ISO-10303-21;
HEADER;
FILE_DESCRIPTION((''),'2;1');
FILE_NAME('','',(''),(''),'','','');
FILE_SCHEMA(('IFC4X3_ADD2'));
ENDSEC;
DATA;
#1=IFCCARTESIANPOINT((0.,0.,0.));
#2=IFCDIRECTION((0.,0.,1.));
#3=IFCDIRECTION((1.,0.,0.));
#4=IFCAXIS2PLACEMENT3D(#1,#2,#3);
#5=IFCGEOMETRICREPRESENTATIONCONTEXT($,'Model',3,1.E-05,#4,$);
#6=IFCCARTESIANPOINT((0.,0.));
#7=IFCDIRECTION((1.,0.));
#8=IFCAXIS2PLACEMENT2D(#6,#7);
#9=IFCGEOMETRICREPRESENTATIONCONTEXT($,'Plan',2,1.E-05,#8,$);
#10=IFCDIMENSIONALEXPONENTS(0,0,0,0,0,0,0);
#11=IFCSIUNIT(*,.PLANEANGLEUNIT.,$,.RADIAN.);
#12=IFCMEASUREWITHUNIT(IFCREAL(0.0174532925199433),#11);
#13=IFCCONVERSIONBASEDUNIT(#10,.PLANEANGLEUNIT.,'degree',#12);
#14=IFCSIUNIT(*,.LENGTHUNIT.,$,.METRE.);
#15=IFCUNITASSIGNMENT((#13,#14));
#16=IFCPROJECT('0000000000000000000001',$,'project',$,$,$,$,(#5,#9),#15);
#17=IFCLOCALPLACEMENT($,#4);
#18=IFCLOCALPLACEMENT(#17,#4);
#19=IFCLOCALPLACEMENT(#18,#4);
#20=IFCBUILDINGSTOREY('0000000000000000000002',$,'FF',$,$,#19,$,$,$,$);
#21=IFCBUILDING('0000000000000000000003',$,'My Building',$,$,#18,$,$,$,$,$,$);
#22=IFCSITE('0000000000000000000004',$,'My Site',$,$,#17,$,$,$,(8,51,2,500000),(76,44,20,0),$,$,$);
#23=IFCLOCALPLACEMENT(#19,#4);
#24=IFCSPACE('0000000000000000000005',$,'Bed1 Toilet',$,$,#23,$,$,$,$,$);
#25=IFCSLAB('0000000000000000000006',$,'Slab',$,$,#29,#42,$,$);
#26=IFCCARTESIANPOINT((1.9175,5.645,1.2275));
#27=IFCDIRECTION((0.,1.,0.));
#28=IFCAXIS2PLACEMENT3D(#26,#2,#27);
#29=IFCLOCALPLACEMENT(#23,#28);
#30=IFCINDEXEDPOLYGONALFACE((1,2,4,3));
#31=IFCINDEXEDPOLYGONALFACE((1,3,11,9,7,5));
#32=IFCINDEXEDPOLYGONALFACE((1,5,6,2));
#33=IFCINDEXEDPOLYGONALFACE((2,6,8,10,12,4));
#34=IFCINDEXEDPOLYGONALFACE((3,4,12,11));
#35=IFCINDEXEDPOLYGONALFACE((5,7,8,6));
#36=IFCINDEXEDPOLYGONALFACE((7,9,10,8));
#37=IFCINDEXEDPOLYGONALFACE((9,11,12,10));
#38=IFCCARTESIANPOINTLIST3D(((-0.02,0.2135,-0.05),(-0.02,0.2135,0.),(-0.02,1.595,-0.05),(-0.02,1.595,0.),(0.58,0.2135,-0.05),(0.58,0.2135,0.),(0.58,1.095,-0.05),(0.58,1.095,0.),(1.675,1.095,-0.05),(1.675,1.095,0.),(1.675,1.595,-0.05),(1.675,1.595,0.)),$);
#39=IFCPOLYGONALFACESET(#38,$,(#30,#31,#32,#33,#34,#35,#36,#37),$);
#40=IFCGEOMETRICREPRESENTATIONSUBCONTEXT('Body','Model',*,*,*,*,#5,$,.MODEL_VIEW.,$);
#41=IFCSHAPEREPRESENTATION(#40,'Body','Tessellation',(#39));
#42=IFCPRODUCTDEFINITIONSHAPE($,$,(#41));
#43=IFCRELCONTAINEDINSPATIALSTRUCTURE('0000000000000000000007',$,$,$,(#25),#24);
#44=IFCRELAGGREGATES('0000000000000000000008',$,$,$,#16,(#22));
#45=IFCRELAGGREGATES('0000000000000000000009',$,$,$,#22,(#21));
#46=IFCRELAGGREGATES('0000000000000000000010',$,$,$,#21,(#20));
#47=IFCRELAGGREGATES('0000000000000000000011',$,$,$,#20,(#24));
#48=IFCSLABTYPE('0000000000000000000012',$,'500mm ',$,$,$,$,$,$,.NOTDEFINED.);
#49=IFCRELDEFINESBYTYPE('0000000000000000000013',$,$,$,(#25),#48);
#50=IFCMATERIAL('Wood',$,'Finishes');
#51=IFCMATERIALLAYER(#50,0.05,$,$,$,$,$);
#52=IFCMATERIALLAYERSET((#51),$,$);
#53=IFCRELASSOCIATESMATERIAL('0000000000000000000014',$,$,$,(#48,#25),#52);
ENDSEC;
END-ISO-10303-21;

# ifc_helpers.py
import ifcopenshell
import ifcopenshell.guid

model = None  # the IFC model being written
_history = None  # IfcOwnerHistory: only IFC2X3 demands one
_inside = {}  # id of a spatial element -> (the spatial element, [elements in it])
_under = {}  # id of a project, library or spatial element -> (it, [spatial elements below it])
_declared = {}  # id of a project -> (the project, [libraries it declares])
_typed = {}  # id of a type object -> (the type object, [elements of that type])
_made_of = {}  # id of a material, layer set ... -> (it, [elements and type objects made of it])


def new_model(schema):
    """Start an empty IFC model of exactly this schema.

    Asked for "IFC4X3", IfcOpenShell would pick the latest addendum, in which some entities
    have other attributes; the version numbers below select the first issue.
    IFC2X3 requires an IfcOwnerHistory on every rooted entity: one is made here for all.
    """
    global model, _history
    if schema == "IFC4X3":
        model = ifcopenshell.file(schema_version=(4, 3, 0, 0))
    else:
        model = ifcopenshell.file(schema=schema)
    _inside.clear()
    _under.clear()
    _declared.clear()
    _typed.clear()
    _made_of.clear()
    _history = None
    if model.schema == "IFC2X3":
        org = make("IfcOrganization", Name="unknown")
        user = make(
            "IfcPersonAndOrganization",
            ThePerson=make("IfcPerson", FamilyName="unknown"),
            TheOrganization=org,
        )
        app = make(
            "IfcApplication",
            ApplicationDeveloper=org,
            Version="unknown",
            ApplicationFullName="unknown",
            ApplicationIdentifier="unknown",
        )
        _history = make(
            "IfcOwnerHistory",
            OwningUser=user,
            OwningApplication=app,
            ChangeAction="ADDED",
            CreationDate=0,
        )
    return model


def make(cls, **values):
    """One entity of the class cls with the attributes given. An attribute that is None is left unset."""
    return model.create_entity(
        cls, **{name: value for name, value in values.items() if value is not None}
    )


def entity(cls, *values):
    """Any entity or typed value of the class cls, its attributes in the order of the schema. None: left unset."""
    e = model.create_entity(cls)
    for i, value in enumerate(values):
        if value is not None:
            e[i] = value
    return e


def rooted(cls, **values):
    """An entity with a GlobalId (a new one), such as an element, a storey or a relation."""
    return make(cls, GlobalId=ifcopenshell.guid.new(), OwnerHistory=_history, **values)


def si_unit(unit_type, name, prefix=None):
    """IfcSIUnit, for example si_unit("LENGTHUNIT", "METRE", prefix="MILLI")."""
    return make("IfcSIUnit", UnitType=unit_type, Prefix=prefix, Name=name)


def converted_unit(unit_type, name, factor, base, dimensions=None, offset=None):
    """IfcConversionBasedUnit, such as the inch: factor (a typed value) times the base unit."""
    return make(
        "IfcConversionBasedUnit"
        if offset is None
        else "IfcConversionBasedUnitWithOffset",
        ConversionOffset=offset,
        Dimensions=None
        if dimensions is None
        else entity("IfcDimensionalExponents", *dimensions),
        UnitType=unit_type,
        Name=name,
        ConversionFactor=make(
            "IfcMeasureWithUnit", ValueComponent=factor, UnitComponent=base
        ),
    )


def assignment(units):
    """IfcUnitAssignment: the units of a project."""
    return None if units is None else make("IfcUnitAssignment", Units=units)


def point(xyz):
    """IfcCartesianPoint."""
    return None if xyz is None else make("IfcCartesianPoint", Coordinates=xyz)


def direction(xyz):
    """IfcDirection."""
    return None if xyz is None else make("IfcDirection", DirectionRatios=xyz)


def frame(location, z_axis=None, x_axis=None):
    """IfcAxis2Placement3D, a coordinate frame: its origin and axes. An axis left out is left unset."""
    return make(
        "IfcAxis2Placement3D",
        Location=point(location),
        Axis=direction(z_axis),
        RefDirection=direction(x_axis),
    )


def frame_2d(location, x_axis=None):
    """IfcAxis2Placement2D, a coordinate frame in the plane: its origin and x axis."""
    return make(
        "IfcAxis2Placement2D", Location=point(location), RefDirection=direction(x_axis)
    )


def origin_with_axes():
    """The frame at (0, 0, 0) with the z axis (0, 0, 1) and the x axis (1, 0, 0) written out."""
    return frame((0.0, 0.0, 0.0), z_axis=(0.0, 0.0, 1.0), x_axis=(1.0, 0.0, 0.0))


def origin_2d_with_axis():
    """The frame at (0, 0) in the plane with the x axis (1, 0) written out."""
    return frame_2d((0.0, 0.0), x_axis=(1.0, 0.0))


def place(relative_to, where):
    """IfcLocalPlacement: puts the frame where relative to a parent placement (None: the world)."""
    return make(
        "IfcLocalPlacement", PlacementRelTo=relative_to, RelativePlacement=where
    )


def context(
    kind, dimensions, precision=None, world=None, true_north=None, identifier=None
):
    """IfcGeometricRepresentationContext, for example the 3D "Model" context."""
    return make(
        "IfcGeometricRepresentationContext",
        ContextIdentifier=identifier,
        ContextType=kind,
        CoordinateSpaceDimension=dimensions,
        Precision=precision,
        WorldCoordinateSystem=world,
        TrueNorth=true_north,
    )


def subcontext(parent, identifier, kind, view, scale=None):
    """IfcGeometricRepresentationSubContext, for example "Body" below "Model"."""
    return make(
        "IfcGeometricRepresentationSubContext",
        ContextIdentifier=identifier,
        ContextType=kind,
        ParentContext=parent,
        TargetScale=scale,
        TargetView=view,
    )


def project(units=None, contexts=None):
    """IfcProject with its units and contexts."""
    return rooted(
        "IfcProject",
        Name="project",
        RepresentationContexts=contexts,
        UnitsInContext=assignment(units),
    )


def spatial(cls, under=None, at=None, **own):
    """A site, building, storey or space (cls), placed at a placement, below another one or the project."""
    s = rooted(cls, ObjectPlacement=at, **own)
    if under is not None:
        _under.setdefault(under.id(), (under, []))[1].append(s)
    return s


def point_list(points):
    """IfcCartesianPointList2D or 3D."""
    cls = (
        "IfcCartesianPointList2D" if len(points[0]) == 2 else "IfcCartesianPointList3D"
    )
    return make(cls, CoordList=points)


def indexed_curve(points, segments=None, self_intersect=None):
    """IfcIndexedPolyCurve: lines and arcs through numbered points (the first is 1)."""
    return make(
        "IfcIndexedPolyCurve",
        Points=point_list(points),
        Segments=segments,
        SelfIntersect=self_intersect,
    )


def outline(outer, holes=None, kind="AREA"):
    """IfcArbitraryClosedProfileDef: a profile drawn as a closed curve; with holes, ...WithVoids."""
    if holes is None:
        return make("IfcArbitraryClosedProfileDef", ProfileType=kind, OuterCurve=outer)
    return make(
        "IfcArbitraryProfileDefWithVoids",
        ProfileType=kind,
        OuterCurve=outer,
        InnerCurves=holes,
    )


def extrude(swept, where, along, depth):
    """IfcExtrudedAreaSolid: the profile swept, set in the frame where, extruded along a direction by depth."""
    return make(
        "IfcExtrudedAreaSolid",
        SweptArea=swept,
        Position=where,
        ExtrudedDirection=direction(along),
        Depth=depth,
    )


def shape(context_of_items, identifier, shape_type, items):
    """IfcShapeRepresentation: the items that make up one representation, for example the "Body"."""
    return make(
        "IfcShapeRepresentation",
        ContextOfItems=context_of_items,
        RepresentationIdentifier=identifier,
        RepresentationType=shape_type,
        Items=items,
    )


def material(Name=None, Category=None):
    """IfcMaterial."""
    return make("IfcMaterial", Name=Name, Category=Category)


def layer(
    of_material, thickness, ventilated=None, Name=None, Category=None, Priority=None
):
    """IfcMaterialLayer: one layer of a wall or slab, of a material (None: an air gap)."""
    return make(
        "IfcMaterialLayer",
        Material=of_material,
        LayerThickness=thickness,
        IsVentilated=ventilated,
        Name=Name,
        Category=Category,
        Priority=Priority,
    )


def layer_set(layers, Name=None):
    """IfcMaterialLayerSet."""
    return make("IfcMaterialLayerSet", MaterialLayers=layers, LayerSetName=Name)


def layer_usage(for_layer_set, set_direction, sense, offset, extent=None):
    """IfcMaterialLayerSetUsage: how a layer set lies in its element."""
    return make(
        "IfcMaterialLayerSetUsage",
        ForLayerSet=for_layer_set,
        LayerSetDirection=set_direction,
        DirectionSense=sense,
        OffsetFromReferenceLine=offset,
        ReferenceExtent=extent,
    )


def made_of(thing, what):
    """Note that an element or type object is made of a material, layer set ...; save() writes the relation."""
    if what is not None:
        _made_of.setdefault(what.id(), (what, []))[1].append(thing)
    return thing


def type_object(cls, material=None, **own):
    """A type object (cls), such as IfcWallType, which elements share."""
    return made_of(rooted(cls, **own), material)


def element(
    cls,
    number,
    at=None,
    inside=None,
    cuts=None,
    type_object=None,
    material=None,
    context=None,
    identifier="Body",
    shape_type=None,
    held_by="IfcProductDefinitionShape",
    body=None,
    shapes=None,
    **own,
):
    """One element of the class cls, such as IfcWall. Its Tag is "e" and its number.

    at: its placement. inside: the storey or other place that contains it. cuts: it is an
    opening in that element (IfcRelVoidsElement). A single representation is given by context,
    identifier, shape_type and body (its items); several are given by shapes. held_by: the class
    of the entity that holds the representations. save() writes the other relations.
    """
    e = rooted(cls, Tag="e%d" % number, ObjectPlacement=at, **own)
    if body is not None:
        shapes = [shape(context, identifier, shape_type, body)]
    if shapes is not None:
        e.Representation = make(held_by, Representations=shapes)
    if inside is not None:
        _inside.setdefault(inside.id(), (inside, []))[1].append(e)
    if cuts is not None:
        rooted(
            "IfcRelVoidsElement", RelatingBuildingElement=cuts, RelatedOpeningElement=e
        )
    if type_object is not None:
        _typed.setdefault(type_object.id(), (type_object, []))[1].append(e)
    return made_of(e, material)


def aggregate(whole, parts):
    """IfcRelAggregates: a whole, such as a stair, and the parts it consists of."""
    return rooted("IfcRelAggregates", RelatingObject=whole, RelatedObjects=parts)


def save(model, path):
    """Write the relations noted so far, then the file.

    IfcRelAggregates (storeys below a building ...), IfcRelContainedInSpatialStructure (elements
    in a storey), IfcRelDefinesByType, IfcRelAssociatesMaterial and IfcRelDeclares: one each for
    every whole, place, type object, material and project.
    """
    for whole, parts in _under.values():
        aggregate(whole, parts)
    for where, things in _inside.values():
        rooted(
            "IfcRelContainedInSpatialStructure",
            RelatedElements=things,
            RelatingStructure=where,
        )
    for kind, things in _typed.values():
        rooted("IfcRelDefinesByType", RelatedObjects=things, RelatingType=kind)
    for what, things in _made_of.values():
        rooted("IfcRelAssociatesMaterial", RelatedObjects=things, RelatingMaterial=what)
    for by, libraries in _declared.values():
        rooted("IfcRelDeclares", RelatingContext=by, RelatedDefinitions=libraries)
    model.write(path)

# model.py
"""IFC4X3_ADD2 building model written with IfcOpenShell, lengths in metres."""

from ifc_helpers import new_model, entity, si_unit, converted_unit, frame, origin_with_axes, origin_2d_with_axis, place, context, subcontext, project, spatial, indexed_curve, outline, extrude, material, layer, layer_set, layer_usage, type_object, element, save


model = new_model("IFC4X3_ADD2")

# Units and contexts
model_context = context("Model", 3, precision=1e-05, world=origin_with_axes())
plan_context = context("Plan", 2, precision=1e-05, world=origin_2d_with_axis())
body_context_1 = subcontext(model_context, "Body", "Model", "MODEL_VIEW")
ifc_project = project(units=[converted_unit("PLANEANGLEUNIT", "degree", entity("IfcReal", 0.0174532925199433), si_unit("PLANEANGLEUNIT", "RADIAN"), dimensions=[0, 0, 0, 0, 0, 0, 0]), si_unit("LENGTHUNIT", "METRE")], contexts=[model_context, plan_context])

# Site, building, storey
site_placement = place(None, origin_with_axes())
site = spatial("IfcSite", under=ifc_project, at=site_placement, Name="My Site", RefLatitude=(8, 51, 2, 500000), RefLongitude=(76, 44, 20, 0))
building_placement = place(site_placement, origin_with_axes())
building = spatial("IfcBuilding", under=site, at=building_placement, Name="My Building")
storey_placement = place(building_placement, origin_with_axes())
storey = spatial("IfcBuildingStorey", under=building, at=storey_placement, Name="FF")

# Shared definitions
space_1_placement = place(storey_placement, origin_with_axes())
space_1 = spatial("IfcSpace", under=storey, at=space_1_placement, Name="Bed1 Toilet")

# Slab
ifc_material_1 = material(Name="Wood", Category="Finishes")
ifc_layer_1 = layer(ifc_material_1, 0.05)
ifc_layer_set_1 = layer_set([ifc_layer_1])
ifc_layer_usage_1 = layer_usage(ifc_layer_set_1, "AXIS3", "POSITIVE", -0.05)
slab_type = type_object("IfcSlabType", Name="500mm ", PredefinedType="NOTDEFINED", material=ifc_layer_set_1)
slab_placement = place(space_1_placement, frame((1.9175, 5.645, 1.2275), z_axis=(0.0, 0.0, 1.0), x_axis=(0.0, 1.0, 0.0)))
element("IfcSlab", 1, at=slab_placement, inside=space_1, type_object=slab_type, material=ifc_layer_usage_1, Name="Slab", context=body_context_1, shape_type="SweptSolid", body=[
    extrude(outline(indexed_curve([(-0.02, 1.595), (1.675, 1.595), (1.675, 1.095), (0.58, 1.095), (0.58, 0.2135), (-0.02, 0.2135), (-0.02, 1.595)])), frame((0.0, 0.0, -0.05), z_axis=(0.0, 0.0, 1.0), x_axis=(1.0, 0.0, 0.0)), (0.0, 0.0, 1.0), 0.05),
])

save(model, "model.ifc")
